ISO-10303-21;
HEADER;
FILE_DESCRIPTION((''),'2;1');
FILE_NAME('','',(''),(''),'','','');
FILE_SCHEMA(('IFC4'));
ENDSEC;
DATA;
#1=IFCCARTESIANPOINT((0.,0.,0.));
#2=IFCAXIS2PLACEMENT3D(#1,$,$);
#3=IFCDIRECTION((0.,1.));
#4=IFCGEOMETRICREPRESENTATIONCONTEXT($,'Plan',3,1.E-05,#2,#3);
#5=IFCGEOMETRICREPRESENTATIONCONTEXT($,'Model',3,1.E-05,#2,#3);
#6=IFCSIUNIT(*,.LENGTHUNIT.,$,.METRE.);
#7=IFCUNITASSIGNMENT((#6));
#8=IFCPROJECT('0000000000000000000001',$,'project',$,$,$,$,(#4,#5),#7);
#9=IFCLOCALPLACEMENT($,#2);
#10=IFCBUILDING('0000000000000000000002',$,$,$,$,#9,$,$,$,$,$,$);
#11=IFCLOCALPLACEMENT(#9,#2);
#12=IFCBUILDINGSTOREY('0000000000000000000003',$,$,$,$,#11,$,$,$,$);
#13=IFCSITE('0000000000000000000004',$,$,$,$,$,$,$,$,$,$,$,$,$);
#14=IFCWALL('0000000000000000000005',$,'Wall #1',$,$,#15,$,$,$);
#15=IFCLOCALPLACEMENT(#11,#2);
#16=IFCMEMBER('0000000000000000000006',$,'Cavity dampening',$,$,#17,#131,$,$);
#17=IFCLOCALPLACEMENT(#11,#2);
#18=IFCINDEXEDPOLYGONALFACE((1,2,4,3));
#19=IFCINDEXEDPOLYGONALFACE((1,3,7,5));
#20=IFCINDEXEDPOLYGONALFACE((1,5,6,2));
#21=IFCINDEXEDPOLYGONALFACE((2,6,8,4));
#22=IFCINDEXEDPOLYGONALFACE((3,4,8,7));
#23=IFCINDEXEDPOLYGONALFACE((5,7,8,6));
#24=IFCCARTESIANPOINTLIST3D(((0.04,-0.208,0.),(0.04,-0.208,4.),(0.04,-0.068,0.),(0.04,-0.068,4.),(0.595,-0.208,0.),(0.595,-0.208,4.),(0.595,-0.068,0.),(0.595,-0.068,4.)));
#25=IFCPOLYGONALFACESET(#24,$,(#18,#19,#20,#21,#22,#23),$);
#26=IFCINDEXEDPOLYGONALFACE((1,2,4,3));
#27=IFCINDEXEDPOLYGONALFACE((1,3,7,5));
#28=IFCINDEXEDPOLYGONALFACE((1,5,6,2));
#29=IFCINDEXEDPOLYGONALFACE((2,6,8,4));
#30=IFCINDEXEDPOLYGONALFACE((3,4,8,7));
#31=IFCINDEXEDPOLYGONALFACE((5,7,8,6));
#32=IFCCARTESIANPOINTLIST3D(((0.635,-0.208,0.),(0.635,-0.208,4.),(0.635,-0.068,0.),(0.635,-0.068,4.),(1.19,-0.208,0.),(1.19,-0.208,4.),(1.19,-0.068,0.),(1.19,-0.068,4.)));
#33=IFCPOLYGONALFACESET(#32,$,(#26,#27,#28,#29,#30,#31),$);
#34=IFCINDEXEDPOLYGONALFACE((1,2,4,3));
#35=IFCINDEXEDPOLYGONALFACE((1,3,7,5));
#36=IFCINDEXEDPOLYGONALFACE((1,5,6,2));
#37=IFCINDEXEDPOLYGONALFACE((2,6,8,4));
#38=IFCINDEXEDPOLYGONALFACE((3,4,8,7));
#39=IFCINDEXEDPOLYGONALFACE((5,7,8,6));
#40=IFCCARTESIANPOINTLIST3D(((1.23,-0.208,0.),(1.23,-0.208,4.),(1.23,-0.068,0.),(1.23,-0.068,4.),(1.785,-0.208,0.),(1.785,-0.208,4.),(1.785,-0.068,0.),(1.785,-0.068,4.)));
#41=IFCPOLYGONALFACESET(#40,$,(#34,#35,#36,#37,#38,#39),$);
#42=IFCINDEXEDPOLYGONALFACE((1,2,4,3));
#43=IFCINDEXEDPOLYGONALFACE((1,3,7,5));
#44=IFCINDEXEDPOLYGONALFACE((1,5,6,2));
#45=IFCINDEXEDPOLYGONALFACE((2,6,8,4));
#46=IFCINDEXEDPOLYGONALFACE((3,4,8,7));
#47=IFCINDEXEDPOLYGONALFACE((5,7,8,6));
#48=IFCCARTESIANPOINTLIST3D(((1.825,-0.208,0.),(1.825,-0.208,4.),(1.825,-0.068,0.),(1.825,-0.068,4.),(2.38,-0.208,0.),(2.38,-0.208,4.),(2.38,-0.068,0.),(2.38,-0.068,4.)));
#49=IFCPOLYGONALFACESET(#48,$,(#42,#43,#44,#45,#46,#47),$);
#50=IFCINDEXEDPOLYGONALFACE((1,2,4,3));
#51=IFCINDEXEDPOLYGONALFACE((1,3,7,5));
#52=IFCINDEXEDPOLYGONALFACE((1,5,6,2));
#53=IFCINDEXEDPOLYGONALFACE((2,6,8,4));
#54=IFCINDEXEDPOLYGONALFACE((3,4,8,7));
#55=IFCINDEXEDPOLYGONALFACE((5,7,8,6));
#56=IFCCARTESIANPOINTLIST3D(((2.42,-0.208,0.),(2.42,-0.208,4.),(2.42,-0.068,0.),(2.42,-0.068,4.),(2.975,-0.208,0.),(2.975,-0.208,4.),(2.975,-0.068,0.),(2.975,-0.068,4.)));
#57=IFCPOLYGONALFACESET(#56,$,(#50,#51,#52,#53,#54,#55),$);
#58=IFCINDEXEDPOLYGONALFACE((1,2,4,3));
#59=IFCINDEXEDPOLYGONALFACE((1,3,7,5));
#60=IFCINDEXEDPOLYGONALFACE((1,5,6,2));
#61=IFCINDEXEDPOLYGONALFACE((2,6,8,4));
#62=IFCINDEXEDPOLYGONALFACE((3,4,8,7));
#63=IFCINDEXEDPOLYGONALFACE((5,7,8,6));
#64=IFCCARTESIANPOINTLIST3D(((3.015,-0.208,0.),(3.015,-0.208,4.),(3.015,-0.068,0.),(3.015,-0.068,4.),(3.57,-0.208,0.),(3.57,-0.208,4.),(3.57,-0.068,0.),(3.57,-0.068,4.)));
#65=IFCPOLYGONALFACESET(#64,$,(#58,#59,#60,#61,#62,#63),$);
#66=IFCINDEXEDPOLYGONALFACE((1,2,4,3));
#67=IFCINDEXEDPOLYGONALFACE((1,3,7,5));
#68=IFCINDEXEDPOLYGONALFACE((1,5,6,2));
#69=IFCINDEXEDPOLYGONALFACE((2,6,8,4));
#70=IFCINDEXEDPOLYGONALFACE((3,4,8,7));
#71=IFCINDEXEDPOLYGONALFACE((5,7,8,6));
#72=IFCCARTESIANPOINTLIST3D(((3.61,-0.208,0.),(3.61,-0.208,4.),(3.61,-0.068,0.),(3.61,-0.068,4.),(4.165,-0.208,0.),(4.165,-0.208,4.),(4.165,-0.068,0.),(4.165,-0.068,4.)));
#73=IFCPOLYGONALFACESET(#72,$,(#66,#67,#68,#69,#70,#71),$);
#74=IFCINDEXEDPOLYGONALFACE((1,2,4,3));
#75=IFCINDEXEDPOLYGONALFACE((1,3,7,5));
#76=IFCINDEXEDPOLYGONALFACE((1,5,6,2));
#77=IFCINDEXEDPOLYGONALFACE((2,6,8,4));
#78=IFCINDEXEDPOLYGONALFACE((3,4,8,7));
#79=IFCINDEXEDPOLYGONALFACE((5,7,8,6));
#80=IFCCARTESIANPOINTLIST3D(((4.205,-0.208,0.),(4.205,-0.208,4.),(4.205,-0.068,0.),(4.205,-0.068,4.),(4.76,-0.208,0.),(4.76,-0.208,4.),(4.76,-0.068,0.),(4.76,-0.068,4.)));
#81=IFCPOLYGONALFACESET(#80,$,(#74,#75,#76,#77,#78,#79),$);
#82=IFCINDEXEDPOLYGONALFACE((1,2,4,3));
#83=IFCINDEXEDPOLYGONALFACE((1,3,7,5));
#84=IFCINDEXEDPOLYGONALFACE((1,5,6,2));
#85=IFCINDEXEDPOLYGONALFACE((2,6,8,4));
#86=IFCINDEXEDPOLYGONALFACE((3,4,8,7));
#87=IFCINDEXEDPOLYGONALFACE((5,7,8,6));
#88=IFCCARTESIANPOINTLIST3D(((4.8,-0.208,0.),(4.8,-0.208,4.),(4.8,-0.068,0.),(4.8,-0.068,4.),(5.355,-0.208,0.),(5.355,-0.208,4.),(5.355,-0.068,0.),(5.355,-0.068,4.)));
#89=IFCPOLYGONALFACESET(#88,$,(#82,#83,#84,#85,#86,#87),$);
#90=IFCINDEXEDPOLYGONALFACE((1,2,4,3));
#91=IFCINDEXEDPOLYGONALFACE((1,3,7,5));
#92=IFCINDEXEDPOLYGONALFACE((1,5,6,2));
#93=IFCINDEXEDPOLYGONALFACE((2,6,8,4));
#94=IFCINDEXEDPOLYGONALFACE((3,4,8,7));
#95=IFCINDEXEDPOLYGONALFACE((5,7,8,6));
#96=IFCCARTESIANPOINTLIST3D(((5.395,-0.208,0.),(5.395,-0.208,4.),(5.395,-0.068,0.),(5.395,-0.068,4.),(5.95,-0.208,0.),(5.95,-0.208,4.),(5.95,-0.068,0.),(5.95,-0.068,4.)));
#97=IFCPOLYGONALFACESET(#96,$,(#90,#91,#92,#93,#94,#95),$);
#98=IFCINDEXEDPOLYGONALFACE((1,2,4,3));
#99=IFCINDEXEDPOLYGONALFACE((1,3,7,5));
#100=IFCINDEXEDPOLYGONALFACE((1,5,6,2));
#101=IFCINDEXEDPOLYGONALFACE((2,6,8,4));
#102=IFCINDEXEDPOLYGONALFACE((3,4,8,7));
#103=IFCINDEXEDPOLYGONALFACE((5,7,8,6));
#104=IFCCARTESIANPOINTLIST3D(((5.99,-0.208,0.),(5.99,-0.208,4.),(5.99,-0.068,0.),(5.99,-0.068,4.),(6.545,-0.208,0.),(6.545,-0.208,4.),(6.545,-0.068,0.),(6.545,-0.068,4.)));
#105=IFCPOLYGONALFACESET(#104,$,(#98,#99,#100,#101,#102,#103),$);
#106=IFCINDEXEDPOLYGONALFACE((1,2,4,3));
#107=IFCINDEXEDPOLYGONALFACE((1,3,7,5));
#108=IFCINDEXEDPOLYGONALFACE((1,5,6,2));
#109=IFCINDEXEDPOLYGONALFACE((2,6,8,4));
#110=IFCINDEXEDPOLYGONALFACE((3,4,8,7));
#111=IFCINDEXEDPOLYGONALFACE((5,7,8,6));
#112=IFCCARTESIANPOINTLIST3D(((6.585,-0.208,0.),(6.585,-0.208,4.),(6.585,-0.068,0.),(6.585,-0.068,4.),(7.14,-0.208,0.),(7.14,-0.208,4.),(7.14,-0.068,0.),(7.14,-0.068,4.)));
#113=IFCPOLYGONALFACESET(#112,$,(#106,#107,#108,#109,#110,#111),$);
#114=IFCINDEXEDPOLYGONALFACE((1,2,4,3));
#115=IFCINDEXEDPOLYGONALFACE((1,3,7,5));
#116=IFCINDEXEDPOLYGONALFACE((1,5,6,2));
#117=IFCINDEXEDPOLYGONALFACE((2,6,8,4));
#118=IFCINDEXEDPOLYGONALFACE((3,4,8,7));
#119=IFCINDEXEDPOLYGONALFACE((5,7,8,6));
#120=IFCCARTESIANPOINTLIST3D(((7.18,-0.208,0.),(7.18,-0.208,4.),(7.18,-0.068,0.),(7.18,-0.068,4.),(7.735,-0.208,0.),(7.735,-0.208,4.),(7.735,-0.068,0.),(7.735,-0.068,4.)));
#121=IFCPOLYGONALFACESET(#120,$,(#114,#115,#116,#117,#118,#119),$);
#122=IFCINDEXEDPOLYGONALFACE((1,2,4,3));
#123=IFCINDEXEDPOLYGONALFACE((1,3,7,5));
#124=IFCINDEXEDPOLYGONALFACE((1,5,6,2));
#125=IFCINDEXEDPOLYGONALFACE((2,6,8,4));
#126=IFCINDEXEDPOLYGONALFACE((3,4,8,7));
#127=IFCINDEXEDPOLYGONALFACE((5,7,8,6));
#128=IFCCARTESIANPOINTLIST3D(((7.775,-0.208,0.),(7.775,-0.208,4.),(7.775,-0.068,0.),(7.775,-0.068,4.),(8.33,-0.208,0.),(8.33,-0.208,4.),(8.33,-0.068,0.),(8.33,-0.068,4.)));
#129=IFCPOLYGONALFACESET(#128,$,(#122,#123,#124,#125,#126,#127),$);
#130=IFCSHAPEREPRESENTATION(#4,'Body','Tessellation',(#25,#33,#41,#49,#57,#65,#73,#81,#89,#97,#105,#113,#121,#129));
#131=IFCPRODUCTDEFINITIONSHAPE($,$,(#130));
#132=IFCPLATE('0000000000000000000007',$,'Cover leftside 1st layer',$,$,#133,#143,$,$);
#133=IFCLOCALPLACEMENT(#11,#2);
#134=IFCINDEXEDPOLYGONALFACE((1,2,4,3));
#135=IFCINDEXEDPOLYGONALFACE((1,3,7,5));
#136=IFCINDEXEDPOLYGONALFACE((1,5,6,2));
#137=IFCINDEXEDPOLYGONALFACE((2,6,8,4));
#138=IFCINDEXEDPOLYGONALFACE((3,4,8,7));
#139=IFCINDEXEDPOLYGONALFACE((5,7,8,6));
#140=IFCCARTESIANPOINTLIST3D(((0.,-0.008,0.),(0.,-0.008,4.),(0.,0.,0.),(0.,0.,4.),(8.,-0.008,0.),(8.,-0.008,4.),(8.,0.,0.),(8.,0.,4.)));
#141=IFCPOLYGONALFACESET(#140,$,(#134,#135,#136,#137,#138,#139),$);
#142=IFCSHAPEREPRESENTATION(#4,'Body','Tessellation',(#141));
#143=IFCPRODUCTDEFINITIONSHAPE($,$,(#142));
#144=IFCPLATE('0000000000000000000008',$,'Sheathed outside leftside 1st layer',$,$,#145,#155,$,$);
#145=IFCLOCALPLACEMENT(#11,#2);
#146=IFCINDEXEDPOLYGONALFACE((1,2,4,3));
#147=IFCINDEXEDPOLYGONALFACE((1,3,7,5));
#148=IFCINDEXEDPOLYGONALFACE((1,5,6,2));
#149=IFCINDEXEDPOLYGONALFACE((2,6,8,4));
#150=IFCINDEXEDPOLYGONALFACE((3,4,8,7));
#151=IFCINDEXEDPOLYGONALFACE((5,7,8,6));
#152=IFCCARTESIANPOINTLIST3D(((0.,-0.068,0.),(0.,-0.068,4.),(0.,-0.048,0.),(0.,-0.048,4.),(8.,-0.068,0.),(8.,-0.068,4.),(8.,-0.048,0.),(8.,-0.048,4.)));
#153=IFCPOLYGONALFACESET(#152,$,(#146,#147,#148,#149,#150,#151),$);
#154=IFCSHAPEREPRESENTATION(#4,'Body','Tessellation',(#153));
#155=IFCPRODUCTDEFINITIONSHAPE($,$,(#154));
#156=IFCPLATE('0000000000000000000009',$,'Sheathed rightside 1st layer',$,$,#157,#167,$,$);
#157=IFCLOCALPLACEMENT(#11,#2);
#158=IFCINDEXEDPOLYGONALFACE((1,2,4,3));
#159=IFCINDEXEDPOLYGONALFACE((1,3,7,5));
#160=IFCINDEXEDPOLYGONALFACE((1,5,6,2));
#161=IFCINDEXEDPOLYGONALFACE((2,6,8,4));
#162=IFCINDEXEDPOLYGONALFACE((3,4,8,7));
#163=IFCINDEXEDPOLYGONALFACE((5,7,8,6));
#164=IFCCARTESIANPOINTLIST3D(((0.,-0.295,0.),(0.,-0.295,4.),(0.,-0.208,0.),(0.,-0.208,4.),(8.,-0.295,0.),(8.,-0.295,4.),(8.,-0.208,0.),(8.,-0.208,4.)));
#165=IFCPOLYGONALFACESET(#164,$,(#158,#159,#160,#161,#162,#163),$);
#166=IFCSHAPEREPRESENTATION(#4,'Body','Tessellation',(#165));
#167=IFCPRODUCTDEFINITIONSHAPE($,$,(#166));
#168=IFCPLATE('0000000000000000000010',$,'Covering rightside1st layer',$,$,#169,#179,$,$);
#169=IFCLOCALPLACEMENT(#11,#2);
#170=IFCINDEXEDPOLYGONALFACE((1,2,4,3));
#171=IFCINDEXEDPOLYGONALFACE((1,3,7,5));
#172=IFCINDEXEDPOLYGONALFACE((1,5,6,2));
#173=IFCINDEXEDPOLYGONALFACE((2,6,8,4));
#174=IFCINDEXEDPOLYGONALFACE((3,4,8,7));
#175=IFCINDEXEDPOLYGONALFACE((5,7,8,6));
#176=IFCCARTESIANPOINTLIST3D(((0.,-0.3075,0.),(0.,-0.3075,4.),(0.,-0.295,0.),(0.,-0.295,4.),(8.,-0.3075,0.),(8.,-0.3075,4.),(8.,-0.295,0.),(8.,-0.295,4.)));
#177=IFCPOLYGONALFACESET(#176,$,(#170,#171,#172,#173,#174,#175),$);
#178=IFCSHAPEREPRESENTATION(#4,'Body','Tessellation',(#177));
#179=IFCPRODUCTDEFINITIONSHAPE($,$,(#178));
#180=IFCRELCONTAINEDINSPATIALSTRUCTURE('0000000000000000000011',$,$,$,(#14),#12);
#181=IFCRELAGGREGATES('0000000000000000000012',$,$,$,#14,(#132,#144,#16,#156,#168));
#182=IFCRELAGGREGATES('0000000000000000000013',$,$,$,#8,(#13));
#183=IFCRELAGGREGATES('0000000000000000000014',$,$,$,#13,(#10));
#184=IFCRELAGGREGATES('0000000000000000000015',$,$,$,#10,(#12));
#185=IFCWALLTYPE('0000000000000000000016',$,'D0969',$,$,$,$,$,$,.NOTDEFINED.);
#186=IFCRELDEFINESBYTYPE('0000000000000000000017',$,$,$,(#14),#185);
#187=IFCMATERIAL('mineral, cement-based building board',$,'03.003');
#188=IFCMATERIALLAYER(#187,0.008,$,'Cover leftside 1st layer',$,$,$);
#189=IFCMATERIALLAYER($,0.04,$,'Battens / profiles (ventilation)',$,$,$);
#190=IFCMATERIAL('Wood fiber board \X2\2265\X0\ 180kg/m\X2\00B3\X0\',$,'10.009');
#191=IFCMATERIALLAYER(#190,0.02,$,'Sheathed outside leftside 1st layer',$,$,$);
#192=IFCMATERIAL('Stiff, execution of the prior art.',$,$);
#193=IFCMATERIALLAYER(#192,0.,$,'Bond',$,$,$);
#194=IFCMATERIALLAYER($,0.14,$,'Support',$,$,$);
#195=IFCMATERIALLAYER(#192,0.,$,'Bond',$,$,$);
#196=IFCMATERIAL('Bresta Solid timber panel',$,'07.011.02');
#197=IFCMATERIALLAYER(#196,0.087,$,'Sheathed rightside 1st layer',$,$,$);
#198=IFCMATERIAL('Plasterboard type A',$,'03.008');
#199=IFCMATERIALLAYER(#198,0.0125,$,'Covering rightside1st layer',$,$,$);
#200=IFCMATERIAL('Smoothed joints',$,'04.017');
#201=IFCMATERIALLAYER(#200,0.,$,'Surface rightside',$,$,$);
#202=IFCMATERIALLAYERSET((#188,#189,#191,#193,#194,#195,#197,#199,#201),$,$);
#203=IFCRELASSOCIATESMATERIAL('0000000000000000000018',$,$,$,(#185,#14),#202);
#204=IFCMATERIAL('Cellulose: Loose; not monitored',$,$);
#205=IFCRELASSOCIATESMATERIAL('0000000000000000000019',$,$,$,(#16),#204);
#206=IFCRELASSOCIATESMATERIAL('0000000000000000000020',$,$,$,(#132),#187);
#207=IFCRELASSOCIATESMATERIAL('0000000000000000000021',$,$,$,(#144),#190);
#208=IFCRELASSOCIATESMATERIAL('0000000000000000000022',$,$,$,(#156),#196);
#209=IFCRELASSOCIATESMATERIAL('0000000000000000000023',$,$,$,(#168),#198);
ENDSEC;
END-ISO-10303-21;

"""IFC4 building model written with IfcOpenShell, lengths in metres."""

from ifc_helpers import new_model, si_unit, direction, frame, frame_2d, origin, origin_with_axes, place, context, project, spatial, rectangle, extrude, material, layer, layer_set, type_object, element, aggregate, save


model = new_model("IFC4")

# Units and contexts
plan_context = context("Plan", 3, precision=1e-05, world=origin(), true_north=direction((0.0, 1.0)))
model_context = context("Model", 3, precision=1e-05, world=origin(), true_north=direction((0.0, 1.0)))
ifc_project = project(units=[si_unit("LENGTHUNIT", "METRE")], contexts=[plan_context, model_context])

# Site, building, storey
site = spatial("IfcSite", under=ifc_project)
building_placement = place(None, origin())
building = spatial("IfcBuilding", under=site, at=building_placement)
storey_placement = place(building_placement, origin())
storey = spatial("IfcBuildingStorey", under=building, at=storey_placement)

# Wall, member, plates
ifc_material_1 = material(Name="mineral, cement-based building board", Category="03.003")
ifc_layer_1 = layer(ifc_material_1, 0.008, Name="Cover leftside 1st layer")
ifc_layer_2 = layer(None, 0.04, Name="Battens / profiles (ventilation)")
ifc_material_2 = material(Name="Wood fiber board ≥ 180kg/m³", Category="10.009")
ifc_layer_3 = layer(ifc_material_2, 0.02, Name="Sheathed outside leftside 1st layer")
ifc_material_3 = material(Name="Stiff, execution of the prior art.")
ifc_layer_4 = layer(ifc_material_3, 0.0, Name="Bond")
ifc_layer_5 = layer(None, 0.14, Name="Support")
ifc_layer_6 = layer(ifc_material_3, 0.0, Name="Bond")
ifc_material_4 = material(Name="Bresta Solid timber panel", Category="07.011.02")
ifc_layer_7 = layer(ifc_material_4, 0.087, Name="Sheathed rightside 1st layer")
ifc_material_5 = material(Name="Plasterboard type A", Category="03.008")
ifc_layer_8 = layer(ifc_material_5, 0.0125, Name="Covering rightside1st layer")
ifc_material_6 = material(Name="Smoothed joints", Category="04.017")
ifc_layer_9 = layer(ifc_material_6, 0.0, Name="Surface rightside")
ifc_layer_set = layer_set([ifc_layer_1, ifc_layer_2, ifc_layer_3, ifc_layer_4, ifc_layer_5, ifc_layer_6, ifc_layer_7, ifc_layer_8, ifc_layer_9])
wall_type = type_object("IfcWallType", Name="D0969", PredefinedType="NOTDEFINED", material=ifc_layer_set)
wall_placement = place(None, frame((0.0, 0.0, 0.0), z_axis=(0.0, -1.0, 0.0), x_axis=(1.0, 0.0, 0.0)))
wall = element("IfcWall", 1, at=wall_placement, inside=storey, type_object=wall_type, material=ifc_layer_set, Name="Wall #1")
ifc_material_7 = material(Name="Cellulose: Loose; not monitored")
member_1_placement = place(wall_placement, origin())
member_1 = element("IfcMember", 2, at=member_1_placement, material=ifc_material_7, Name="Cavity dampening", context=plan_context, shape_type="SweptSolid", body=[
    extrude(rectangle(XDim=0.555, YDim=0.14, at=frame_2d((0.2775, 0.07), x_axis=(1.0, 0.0))), frame((0.04, 4.0, 0.068), z_axis=(0.0, -1.0, 0.0), x_axis=(1.0, 0.0, 0.0)), (0.0, 0.0, 1.0), 4.0),
    extrude(rectangle(XDim=0.555, YDim=0.14, at=frame_2d((0.2775, 0.07), x_axis=(1.0, 0.0))), frame((0.635, 4.0, 0.068), z_axis=(0.0, -1.0, 0.0), x_axis=(1.0, 0.0, 0.0)), (0.0, 0.0, 1.0), 4.0),
    extrude(rectangle(XDim=0.555, YDim=0.14, at=frame_2d((0.2775, 0.07), x_axis=(1.0, 0.0))), frame((1.23, 4.0, 0.068), z_axis=(0.0, -1.0, 0.0), x_axis=(1.0, 0.0, 0.0)), (0.0, 0.0, 1.0), 4.0),
    extrude(rectangle(XDim=0.555, YDim=0.14, at=frame_2d((0.2775, 0.07), x_axis=(1.0, 0.0))), frame((1.825, 4.0, 0.068), z_axis=(0.0, -1.0, 0.0), x_axis=(1.0, 0.0, 0.0)), (0.0, 0.0, 1.0), 4.0),
    extrude(rectangle(XDim=0.555, YDim=0.14, at=frame_2d((0.2775, 0.07), x_axis=(1.0, 0.0))), frame((2.42, 4.0, 0.068), z_axis=(0.0, -1.0, 0.0), x_axis=(1.0, 0.0, 0.0)), (0.0, 0.0, 1.0), 4.0),
    extrude(rectangle(XDim=0.555, YDim=0.14, at=frame_2d((0.2775, 0.07), x_axis=(1.0, 0.0))), frame((3.015, 4.0, 0.068), z_axis=(0.0, -1.0, 0.0), x_axis=(1.0, 0.0, 0.0)), (0.0, 0.0, 1.0), 4.0),
    extrude(rectangle(XDim=0.555, YDim=0.14, at=frame_2d((0.2775, 0.07), x_axis=(1.0, 0.0))), frame((3.61, 4.0, 0.068), z_axis=(0.0, -1.0, 0.0), x_axis=(1.0, 0.0, 0.0)), (0.0, 0.0, 1.0), 4.0),
    extrude(rectangle(XDim=0.555, YDim=0.14, at=frame_2d((0.2775, 0.07), x_axis=(1.0, 0.0))), frame((4.205, 4.0, 0.068), z_axis=(0.0, -1.0, 0.0), x_axis=(1.0, 0.0, 0.0)), (0.0, 0.0, 1.0), 4.0),
    extrude(rectangle(XDim=0.555, YDim=0.14, at=frame_2d((0.2775, 0.07), x_axis=(1.0, 0.0))), frame((4.8, 4.0, 0.068), z_axis=(0.0, -1.0, 0.0), x_axis=(1.0, 0.0, 0.0)), (0.0, 0.0, 1.0), 4.0),
    extrude(rectangle(XDim=0.555, YDim=0.14, at=frame_2d((0.2775, 0.07), x_axis=(1.0, 0.0))), frame((5.395, 4.0, 0.068), z_axis=(0.0, -1.0, 0.0), x_axis=(1.0, 0.0, 0.0)), (0.0, 0.0, 1.0), 4.0),
    extrude(rectangle(XDim=0.555, YDim=0.14, at=frame_2d((0.2775, 0.07), x_axis=(1.0, 0.0))), frame((5.99, 4.0, 0.068), z_axis=(0.0, -1.0, 0.0), x_axis=(1.0, 0.0, 0.0)), (0.0, 0.0, 1.0), 4.0),
    extrude(rectangle(XDim=0.555, YDim=0.14, at=frame_2d((0.2775, 0.07), x_axis=(1.0, 0.0))), frame((6.585, 4.0, 0.068), z_axis=(0.0, -1.0, 0.0), x_axis=(1.0, 0.0, 0.0)), (0.0, 0.0, 1.0), 4.0),
    extrude(rectangle(XDim=0.555, YDim=0.14, at=frame_2d((0.2775, 0.07), x_axis=(1.0, 0.0))), frame((7.18, 4.0, 0.068), z_axis=(0.0, -1.0, 0.0), x_axis=(1.0, 0.0, 0.0)), (0.0, 0.0, 1.0), 4.0),
    extrude(rectangle(XDim=0.555, YDim=0.14, at=frame_2d((0.2775, 0.07), x_axis=(1.0, 0.0))), frame((7.775, 4.0, 0.068), z_axis=(0.0, -1.0, 0.0), x_axis=(1.0, 0.0, 0.0)), (0.0, 0.0, 1.0), 4.0),
])
plate_1_placement = place(wall_placement, origin())
plate_1 = element("IfcPlate", 3, at=plate_1_placement, material=ifc_material_1, Name="Cover leftside 1st layer", context=plan_context, shape_type="SweptSolid", body=[
    extrude(rectangle(XDim=8.0, YDim=4.0, at=frame_2d((4.0, 2.0), x_axis=(1.0, 0.0))), origin_with_axes(), (0.0, 0.0, 1.0), 0.008),
])
plate_2_placement = place(wall_placement, origin())
plate_2 = element("IfcPlate", 4, at=plate_2_placement, material=ifc_material_2, Name="Sheathed outside leftside 1st layer", context=plan_context, shape_type="SweptSolid", body=[
    extrude(rectangle(XDim=8.0, YDim=4.0, at=frame_2d((4.0, 2.0), x_axis=(1.0, 0.0))), frame((0.0, 0.0, 0.048), z_axis=(0.0, 0.0, 1.0), x_axis=(1.0, 0.0, 0.0)), (0.0, 0.0, 1.0), 0.02),
])
plate_3_placement = place(wall_placement, origin())
plate_3 = element("IfcPlate", 5, at=plate_3_placement, material=ifc_material_4, Name="Sheathed rightside 1st layer", context=plan_context, shape_type="SweptSolid", body=[
    extrude(rectangle(XDim=8.0, YDim=4.0, at=frame_2d((4.0, 2.0), x_axis=(1.0, 0.0))), frame((0.0, 0.0, 0.208), z_axis=(0.0, 0.0, 1.0), x_axis=(1.0, 0.0, 0.0)), (0.0, 0.0, 1.0), 0.087),
])
plate_4_placement = place(wall_placement, origin())
plate_4 = element("IfcPlate", 6, at=plate_4_placement, material=ifc_material_5, Name="Covering rightside1st layer", context=plan_context, shape_type="SweptSolid", body=[
    extrude(rectangle(XDim=8.0, YDim=4.0, at=frame_2d((4.0, 2.0), x_axis=(1.0, 0.0))), frame((0.0, 0.0, 0.295), z_axis=(0.0, 0.0, 1.0), x_axis=(1.0, 0.0, 0.0)), (0.0, 0.0, 1.0), 0.0125),
])
aggregate(wall, [plate_1, plate_2, member_1, plate_3, plate_4])

save(model, "model.ifc")
